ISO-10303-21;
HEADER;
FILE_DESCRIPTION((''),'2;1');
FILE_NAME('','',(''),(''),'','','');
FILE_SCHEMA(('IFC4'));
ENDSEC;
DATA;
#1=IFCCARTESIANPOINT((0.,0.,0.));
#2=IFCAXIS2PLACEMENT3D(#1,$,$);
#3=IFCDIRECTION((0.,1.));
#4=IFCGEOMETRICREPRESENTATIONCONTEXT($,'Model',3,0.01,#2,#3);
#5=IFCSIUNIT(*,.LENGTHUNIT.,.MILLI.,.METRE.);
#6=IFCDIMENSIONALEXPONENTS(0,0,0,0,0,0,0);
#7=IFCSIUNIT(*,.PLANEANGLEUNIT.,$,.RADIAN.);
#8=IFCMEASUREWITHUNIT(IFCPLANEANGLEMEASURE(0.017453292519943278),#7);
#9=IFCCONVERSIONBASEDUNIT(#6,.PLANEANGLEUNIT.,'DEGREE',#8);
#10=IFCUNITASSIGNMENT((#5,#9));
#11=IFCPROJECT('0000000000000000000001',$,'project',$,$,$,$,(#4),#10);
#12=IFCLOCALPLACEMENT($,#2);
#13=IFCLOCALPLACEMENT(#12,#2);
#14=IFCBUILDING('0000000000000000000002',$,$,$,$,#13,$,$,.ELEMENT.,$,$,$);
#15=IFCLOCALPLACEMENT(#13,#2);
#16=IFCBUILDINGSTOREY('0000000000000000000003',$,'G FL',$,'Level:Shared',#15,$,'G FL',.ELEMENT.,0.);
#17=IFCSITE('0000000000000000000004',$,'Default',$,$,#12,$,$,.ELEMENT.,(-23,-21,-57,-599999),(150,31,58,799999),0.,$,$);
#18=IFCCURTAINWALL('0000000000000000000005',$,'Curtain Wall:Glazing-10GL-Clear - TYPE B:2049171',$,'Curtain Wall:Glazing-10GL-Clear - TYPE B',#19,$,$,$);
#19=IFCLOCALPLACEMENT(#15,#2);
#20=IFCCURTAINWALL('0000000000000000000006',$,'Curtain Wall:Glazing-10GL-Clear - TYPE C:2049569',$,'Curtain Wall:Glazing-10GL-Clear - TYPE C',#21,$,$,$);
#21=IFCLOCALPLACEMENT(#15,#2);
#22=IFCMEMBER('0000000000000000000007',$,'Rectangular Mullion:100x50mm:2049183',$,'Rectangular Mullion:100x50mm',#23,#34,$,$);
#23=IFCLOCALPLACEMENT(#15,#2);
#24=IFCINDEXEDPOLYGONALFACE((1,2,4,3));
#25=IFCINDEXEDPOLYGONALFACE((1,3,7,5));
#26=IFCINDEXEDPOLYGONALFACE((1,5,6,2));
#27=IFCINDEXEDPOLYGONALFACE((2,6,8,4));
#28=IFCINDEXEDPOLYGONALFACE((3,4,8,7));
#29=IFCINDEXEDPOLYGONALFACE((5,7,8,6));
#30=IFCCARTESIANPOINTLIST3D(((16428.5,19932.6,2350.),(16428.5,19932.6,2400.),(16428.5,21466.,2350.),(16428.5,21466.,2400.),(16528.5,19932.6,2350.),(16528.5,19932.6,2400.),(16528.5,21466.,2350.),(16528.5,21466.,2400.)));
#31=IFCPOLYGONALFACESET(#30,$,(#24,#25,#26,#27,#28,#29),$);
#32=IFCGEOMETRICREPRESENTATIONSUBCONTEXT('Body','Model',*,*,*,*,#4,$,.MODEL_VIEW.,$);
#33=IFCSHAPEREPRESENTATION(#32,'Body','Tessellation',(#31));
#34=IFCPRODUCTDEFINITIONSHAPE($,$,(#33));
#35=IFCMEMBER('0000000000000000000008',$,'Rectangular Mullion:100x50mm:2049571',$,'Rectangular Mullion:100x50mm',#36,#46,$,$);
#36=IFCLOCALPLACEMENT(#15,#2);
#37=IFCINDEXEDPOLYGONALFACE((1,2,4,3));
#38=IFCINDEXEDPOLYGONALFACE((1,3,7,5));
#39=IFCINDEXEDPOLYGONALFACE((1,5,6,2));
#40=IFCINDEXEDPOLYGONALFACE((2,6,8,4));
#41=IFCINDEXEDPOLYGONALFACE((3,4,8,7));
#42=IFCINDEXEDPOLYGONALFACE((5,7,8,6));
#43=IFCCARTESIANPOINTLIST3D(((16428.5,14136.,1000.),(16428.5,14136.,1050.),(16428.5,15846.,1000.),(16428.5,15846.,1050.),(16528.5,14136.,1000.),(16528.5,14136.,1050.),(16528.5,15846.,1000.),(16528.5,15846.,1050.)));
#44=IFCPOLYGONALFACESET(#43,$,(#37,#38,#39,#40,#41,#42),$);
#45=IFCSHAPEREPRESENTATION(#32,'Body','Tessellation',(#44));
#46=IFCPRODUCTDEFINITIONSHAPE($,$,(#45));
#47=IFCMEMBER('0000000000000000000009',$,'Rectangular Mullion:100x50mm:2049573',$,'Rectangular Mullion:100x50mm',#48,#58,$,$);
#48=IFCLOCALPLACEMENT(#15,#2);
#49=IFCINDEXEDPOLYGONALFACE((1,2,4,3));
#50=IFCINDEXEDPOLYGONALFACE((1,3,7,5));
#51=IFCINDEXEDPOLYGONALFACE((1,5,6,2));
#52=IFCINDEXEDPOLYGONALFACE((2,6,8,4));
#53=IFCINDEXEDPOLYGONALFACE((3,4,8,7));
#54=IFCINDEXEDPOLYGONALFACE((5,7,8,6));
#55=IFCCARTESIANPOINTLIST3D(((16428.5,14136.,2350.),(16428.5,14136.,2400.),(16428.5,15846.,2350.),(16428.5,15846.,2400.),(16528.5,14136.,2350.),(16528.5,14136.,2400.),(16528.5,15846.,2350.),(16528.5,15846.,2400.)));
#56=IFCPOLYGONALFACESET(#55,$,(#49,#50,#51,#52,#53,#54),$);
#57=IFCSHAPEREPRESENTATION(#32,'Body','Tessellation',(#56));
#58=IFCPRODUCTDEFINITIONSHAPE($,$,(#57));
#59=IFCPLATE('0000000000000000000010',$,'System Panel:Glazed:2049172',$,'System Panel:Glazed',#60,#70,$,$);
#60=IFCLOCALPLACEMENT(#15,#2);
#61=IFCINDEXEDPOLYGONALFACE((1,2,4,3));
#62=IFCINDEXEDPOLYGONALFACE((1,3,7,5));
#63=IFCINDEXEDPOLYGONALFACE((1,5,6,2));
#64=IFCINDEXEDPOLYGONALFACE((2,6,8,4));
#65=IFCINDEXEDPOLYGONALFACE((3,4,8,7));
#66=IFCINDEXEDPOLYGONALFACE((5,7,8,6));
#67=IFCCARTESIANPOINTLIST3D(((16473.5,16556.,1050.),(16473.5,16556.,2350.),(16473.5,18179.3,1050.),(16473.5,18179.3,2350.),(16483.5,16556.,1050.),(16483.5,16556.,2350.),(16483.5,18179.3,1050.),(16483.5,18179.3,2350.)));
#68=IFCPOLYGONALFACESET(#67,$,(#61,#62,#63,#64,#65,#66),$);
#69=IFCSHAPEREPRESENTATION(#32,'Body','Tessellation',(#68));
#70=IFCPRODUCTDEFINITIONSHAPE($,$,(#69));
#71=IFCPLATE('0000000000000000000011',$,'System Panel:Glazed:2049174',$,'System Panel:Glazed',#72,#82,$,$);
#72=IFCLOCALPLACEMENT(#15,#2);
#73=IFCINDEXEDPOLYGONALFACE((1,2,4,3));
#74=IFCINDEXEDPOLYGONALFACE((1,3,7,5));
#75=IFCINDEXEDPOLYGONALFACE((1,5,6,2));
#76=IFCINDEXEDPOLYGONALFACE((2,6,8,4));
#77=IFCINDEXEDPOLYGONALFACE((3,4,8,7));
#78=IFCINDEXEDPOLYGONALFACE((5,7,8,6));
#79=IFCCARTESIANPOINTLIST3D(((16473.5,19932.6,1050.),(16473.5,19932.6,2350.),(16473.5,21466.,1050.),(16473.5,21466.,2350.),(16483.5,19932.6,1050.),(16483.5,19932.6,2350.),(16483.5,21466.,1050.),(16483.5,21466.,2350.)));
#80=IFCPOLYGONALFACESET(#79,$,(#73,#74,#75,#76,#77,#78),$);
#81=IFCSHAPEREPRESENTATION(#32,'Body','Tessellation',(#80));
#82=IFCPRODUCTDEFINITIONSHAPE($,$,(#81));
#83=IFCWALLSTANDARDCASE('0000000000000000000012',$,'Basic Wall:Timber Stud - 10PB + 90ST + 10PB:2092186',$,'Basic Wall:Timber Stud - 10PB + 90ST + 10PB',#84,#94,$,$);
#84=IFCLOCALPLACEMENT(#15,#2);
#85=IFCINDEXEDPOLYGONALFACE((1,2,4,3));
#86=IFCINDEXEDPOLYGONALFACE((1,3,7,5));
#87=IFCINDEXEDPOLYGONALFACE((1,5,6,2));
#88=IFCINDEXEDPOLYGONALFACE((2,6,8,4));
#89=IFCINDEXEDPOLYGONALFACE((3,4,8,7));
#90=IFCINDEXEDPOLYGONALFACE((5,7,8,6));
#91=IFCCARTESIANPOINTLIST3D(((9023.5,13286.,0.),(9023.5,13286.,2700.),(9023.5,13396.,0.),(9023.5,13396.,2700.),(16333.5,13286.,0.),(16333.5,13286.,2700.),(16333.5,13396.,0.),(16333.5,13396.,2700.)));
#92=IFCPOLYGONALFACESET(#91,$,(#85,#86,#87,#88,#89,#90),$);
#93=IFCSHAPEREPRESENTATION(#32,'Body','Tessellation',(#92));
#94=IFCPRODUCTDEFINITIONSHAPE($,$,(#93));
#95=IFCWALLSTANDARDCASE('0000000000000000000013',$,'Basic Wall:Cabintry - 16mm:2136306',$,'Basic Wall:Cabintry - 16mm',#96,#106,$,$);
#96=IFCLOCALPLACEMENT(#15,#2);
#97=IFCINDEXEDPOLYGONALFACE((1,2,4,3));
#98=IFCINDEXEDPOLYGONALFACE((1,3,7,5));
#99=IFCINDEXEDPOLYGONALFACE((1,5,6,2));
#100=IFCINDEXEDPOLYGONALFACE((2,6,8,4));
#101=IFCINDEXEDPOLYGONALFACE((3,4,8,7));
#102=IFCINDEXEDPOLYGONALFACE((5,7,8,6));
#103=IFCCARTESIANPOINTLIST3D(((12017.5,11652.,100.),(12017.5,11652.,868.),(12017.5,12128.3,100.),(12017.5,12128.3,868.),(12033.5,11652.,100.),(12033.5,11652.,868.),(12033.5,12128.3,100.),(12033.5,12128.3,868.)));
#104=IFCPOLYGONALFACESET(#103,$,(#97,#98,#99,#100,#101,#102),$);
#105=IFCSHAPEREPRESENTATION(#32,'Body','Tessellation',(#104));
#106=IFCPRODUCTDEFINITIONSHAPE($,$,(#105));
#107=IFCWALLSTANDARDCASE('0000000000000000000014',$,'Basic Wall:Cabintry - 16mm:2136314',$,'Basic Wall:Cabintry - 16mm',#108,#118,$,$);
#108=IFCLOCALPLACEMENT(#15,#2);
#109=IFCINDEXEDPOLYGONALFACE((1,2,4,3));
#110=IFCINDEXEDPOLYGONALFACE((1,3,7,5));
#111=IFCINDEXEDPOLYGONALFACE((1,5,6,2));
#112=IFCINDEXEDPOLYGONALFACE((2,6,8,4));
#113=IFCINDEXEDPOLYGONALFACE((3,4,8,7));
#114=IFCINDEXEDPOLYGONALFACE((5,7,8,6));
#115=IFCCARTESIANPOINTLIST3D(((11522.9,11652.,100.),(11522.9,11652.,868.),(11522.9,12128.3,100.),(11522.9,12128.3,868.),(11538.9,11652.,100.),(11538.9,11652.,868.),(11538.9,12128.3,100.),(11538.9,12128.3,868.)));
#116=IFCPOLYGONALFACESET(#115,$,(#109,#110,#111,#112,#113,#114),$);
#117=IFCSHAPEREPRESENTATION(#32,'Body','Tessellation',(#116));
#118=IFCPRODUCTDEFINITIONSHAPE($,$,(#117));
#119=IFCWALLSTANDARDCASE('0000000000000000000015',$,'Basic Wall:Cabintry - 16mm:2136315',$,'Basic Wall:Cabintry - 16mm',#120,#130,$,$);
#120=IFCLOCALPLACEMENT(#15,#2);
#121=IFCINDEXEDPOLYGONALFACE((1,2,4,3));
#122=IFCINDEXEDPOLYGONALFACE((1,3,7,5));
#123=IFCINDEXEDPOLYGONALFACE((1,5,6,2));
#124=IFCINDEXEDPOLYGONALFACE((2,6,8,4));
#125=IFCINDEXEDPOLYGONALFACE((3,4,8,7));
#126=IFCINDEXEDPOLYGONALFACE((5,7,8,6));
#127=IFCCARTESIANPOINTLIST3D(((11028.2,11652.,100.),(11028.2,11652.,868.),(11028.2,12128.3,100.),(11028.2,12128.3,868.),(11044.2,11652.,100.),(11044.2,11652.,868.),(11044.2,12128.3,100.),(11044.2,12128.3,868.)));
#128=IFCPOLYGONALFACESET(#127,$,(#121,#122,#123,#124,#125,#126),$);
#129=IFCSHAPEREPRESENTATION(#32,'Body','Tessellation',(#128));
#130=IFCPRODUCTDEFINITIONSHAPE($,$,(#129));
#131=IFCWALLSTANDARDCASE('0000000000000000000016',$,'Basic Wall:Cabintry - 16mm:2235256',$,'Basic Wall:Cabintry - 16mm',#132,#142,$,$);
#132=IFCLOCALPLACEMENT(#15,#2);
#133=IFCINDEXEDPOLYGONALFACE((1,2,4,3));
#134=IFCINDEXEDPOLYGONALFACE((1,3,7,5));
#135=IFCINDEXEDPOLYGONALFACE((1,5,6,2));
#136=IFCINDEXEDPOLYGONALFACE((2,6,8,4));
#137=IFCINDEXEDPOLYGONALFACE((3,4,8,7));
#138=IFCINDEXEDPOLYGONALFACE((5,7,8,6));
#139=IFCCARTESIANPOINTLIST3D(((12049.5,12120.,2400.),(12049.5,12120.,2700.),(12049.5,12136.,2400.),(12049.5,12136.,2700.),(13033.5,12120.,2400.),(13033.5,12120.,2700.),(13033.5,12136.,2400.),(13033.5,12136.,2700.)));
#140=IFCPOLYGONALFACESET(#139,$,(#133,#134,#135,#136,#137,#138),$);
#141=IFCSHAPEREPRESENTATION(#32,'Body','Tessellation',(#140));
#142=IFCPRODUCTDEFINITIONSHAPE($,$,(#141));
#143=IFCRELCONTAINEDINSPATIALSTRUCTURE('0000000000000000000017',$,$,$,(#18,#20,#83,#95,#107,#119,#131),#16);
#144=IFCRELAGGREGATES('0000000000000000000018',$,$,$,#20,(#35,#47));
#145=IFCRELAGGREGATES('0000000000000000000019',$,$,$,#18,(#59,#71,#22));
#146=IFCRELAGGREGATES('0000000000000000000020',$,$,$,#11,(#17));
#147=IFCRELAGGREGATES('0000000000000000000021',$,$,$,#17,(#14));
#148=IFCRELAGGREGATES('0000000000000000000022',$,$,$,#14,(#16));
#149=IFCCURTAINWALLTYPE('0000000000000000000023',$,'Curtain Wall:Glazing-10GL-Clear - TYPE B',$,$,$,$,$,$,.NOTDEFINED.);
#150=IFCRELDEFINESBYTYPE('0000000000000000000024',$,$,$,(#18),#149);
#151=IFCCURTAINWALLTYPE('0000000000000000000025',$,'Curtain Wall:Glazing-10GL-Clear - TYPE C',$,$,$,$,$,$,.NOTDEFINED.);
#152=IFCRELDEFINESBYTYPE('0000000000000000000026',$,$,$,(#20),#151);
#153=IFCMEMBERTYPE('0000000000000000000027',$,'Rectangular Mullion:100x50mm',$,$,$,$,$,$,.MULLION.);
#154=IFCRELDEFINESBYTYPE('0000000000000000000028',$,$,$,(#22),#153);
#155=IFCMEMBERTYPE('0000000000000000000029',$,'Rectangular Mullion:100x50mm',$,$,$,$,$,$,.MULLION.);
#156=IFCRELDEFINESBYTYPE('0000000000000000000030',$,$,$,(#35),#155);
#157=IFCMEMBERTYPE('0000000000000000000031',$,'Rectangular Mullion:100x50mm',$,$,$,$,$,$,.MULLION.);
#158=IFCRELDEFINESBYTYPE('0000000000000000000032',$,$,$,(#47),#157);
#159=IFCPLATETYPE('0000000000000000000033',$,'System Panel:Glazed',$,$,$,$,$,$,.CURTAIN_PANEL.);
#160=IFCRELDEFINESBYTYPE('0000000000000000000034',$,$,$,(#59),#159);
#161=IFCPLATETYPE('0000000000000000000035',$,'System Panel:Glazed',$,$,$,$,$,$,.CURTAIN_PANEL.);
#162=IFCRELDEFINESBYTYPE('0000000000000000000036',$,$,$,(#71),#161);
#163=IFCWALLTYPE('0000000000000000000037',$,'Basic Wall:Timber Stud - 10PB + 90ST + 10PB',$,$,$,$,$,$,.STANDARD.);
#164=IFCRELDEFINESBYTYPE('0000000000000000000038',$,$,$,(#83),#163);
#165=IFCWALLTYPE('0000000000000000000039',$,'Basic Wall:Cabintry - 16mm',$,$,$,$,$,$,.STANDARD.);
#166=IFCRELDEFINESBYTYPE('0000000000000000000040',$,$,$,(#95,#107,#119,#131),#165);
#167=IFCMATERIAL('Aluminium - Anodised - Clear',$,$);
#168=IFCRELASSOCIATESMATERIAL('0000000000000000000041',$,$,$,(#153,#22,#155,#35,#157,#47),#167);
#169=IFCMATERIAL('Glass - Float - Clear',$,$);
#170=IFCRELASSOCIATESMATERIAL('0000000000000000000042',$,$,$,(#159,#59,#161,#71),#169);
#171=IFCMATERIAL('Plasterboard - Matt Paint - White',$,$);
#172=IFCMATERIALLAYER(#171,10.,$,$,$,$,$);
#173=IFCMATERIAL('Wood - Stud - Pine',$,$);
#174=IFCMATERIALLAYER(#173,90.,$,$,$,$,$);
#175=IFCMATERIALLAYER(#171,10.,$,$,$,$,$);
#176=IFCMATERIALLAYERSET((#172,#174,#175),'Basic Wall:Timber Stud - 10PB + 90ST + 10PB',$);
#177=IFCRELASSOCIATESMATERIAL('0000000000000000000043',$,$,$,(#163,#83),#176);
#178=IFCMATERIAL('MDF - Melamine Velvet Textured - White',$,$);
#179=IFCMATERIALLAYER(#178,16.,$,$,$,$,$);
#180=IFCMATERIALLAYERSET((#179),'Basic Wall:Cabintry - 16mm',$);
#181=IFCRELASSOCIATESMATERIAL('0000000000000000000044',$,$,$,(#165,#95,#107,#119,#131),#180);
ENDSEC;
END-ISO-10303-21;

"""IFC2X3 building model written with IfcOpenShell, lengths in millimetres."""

from ifc_helpers import new_model, entity, si_unit, converted_unit, direction, frame, frame_2d, origin, origin_2d_with_axis, place, context, subcontext, project, spatial, rectangle, extrude, source, transform, mapped, material, layer, layer_set, layer_usage, type_object, type_shapes, element, aggregate, save


model = new_model("IFC2X3")

# Units and contexts
model_context = context("Model", 3, precision=0.01, world=origin(), true_north=direction((0.0, 1.0)))
body_context = subcontext(model_context, "Body", "Model", "MODEL_VIEW")
ifc_project = project(units=[si_unit("LENGTHUNIT", "METRE", prefix="MILLI"), converted_unit("PLANEANGLEUNIT", "DEGREE", entity("IfcPlaneAngleMeasure", 0.017453292519943278), si_unit("PLANEANGLEUNIT", "RADIAN"), dimensions=[0, 0, 0, 0, 0, 0, 0])], contexts=[model_context])

# Site, building, storey
site_placement = place(None, origin())
site = spatial("IfcSite", under=ifc_project, at=site_placement, Name="Default", CompositionType="ELEMENT", RefLatitude=(-23, -21, -57, -599999), RefLongitude=(150, 31, 58, 799999), RefElevation=0.0)
building_placement = place(site_placement, origin())
building = spatial("IfcBuilding", under=site, at=building_placement, CompositionType="ELEMENT")
storey_placement = place(building_placement, origin())
storey = spatial("IfcBuildingStorey", under=building, at=storey_placement, Name="G FL", ObjectType="Level:Shared", LongName="G FL", CompositionType="ELEMENT", Elevation=0.0)

# Curtain walls
curtain_wall_type_1 = type_object("IfcCurtainWallType", Name="Curtain Wall:Glazing-10GL-Clear - TYPE B", PredefinedType="NOTDEFINED")
curtain_wall_1_placement = place(storey_placement, origin())
curtain_wall_1 = element("IfcCurtainWall", 1, at=curtain_wall_1_placement, inside=storey, type_object=curtain_wall_type_1, Name="Curtain Wall:Glazing-10GL-Clear - TYPE B:2049171", ObjectType="Curtain Wall:Glazing-10GL-Clear - TYPE B")
ifc_material_1 = material(Name="Aluminium - Anodised - Clear")
curtain_wall_type_2 = type_object("IfcCurtainWallType", Name="Curtain Wall:Glazing-10GL-Clear - TYPE C", PredefinedType="NOTDEFINED")
curtain_wall_2_placement = place(storey_placement, origin())
curtain_wall_2 = element("IfcCurtainWall", 2, at=curtain_wall_2_placement, inside=storey, type_object=curtain_wall_type_2, Name="Curtain Wall:Glazing-10GL-Clear - TYPE C:2049569", ObjectType="Curtain Wall:Glazing-10GL-Clear - TYPE C")

# Members
member_type_1 = type_object("IfcMemberType", Name="Rectangular Mullion:100x50mm", PredefinedType="MULLION", material=ifc_material_1)
shared_shape_1 = source(origin(), body_context, "Body", "SweptSolid", [
    extrude(rectangle(XDim=50.0, YDim=100.0, at=frame_2d((0.0, 0.0), x_axis=(1.0, 0.0))), frame((-25.0, 0.0, -1533.3), z_axis=(0.0, 0.0, 1.0), x_axis=(-1.0, 0.0, 0.0)), (0.0, 0.0, 1.0), 1533.3),
])
type_shapes(member_type_1, [shared_shape_1])
member_1_placement = place(curtain_wall_1_placement, frame((16478.5, 21466.0, 2400.0), z_axis=(0.0, 1.0, 0.0), x_axis=(0.0, 0.0, 1.0)))
member_1 = element("IfcMember", 3, at=member_1_placement, type_object=member_type_1, material=ifc_material_1, Name="Rectangular Mullion:100x50mm:2049183", ObjectType="Rectangular Mullion:100x50mm", context=body_context, shape_type="MappedRepresentation", body=[
    mapped(shared_shape_1, transform((0.0, 0.0, 0.0), scale=1.0)),
])
member_type_2 = type_object("IfcMemberType", Name="Rectangular Mullion:100x50mm", PredefinedType="MULLION", material=ifc_material_1)
shared_shape_2 = source(origin(), body_context, "Body", "SweptSolid", [
    extrude(rectangle(XDim=50.0, YDim=100.0, at=frame_2d((0.0, 0.0), x_axis=(1.0, 0.0))), frame((-25.0, 0.0, -1710.0), z_axis=(0.0, 0.0, 1.0), x_axis=(-1.0, 0.0, 0.0)), (0.0, 0.0, 1.0), 1710.0),
])
type_shapes(member_type_2, [shared_shape_2])
member_2_placement = place(curtain_wall_2_placement, frame((16478.5, 15846.0, 1000.0), z_axis=(0.0, 1.0, 0.0), x_axis=(0.0, 0.0, -1.0)))
member_2 = element("IfcMember", 4, at=member_2_placement, type_object=member_type_2, material=ifc_material_1, Name="Rectangular Mullion:100x50mm:2049571", ObjectType="Rectangular Mullion:100x50mm", context=body_context, shape_type="MappedRepresentation", body=[
    mapped(shared_shape_2, transform((0.0, 0.0, 0.0), scale=1.0)),
])
member_type_3 = type_object("IfcMemberType", Name="Rectangular Mullion:100x50mm", PredefinedType="MULLION", material=ifc_material_1)
shared_shape_3 = source(origin(), body_context, "Body", "SweptSolid", [
    extrude(rectangle(XDim=50.0, YDim=100.0, at=frame_2d((0.0, 0.0), x_axis=(1.0, 0.0))), frame((-25.0, 0.0, -1710.0), z_axis=(0.0, 0.0, 1.0), x_axis=(-1.0, 0.0, 0.0)), (0.0, 0.0, 1.0), 1710.0),
])
type_shapes(member_type_3, [shared_shape_3])
member_3_placement = place(curtain_wall_2_placement, frame((16478.5, 14136.0, 2400.0), z_axis=(0.0, -1.0, 0.0), x_axis=(0.0, 0.0, 1.0)))
member_3 = element("IfcMember", 5, at=member_3_placement, type_object=member_type_3, material=ifc_material_1, Name="Rectangular Mullion:100x50mm:2049573", ObjectType="Rectangular Mullion:100x50mm", context=body_context, shape_type="MappedRepresentation", body=[
    mapped(shared_shape_3, transform((0.0, 0.0, 0.0), scale=1.0)),
])
aggregate(curtain_wall_2, [member_2, member_3])

# Plates
ifc_material_2 = material(Name="Glass - Float - Clear")
plate_type_1 = type_object("IfcPlateType", Name="System Panel:Glazed", PredefinedType="CURTAIN_PANEL", material=ifc_material_2)
shared_shape_4 = source(origin(), body_context, "Body", "SweptSolid", [
    extrude(rectangle(XDim=10.0, YDim=1623.3, at=origin_2d_with_axis()), frame((0.0, 0.0, 0.0), z_axis=(0.0, 0.0, 1.0), x_axis=(0.0, 1.0, 0.0)), (0.0, 0.0, 1.0), 1300.0),
])
type_shapes(plate_type_1, [shared_shape_4])
plate_1_placement = place(curtain_wall_1_placement, frame((16478.5, 17367.6, 1050.0), z_axis=(0.0, 0.0, 1.0), x_axis=(0.0, 1.0, 0.0)))
plate_1 = element("IfcPlate", 6, at=plate_1_placement, type_object=plate_type_1, material=ifc_material_2, Name="System Panel:Glazed:2049172", ObjectType="System Panel:Glazed", context=body_context, shape_type="MappedRepresentation", body=[
    mapped(shared_shape_4, transform((0.0, 0.0, 0.0), scale=1.0)),
])
plate_type_2 = type_object("IfcPlateType", Name="System Panel:Glazed", PredefinedType="CURTAIN_PANEL", material=ifc_material_2)
shared_shape_5 = source(origin(), body_context, "Body", "SweptSolid", [
    extrude(rectangle(XDim=10.0, YDim=1533.3, at=origin_2d_with_axis()), frame((0.0, 0.0, 0.0), z_axis=(0.0, 0.0, 1.0), x_axis=(0.0, 1.0, 0.0)), (0.0, 0.0, 1.0), 1300.0),
])
type_shapes(plate_type_2, [shared_shape_5])
plate_2_placement = place(curtain_wall_1_placement, frame((16478.5, 20699.3, 1050.0), z_axis=(0.0, 0.0, 1.0), x_axis=(0.0, 1.0, 0.0)))
plate_2 = element("IfcPlate", 7, at=plate_2_placement, type_object=plate_type_2, material=ifc_material_2, Name="System Panel:Glazed:2049174", ObjectType="System Panel:Glazed", context=body_context, shape_type="MappedRepresentation", body=[
    mapped(shared_shape_5, transform((0.0, 0.0, 0.0), scale=1.0)),
])
aggregate(curtain_wall_1, [plate_1, plate_2, member_1])

# Walls
ifc_material_3 = material(Name="Plasterboard - Matt Paint - White")
ifc_layer_1 = layer(ifc_material_3, 10.0)
ifc_material_4 = material(Name="Wood - Stud - Pine")
ifc_layer_2 = layer(ifc_material_4, 90.0)
ifc_layer_3 = layer(ifc_material_3, 10.0)
ifc_layer_set_1 = layer_set([ifc_layer_1, ifc_layer_2, ifc_layer_3], Name="Basic Wall:Timber Stud - 10PB + 90ST + 10PB")
ifc_layer_usage_1 = layer_usage(ifc_layer_set_1, "AXIS2", "NEGATIVE", 55.0)
wall_type_1 = type_object("IfcWallType", Name="Basic Wall:Timber Stud - 10PB + 90ST + 10PB", PredefinedType="STANDARD", material=ifc_layer_set_1)
wall_1_placement = place(storey_placement, frame((16333.5, 13341.0, 0.0), z_axis=(0.0, 0.0, 1.0), x_axis=(-1.0, 0.0, 0.0)))
element("IfcWallStandardCase", 8, at=wall_1_placement, inside=storey, type_object=wall_type_1, material=ifc_layer_usage_1, Name="Basic Wall:Timber Stud - 10PB + 90ST + 10PB:2092186", ObjectType="Basic Wall:Timber Stud - 10PB + 90ST + 10PB", context=body_context, shape_type="SweptSolid", body=[
    extrude(rectangle(XDim=7310.0, YDim=110.0, at=frame_2d((3655.0, 0.0), x_axis=(-1.0, 0.0))), origin(), (0.0, 0.0, 1.0), 2700.0),
])
ifc_material_5 = material(Name="MDF - Melamine Velvet Textured - White")
ifc_layer_4 = layer(ifc_material_5, 16.0)
ifc_layer_set_2 = layer_set([ifc_layer_4], Name="Basic Wall:Cabintry - 16mm")
ifc_layer_usage_2 = layer_usage(ifc_layer_set_2, "AXIS2", "POSITIVE", -8.0)
wall_type_2 = type_object("IfcWallType", Name="Basic Wall:Cabintry - 16mm", PredefinedType="STANDARD", material=ifc_layer_set_2)
wall_2_placement = place(storey_placement, frame((12025.5, 12128.3, 100.0), z_axis=(0.0, 0.0, 1.0), x_axis=(0.0, -1.0, 0.0)))
element("IfcWallStandardCase", 9, at=wall_2_placement, inside=storey, type_object=wall_type_2, material=ifc_layer_usage_2, Name="Basic Wall:Cabintry - 16mm:2136306", ObjectType="Basic Wall:Cabintry - 16mm", context=body_context, shape_type="SweptSolid", body=[
    extrude(rectangle(XDim=476.4, YDim=16.0, at=frame_2d((238.2, 0.0), x_axis=(-1.0, 0.0))), origin(), (0.0, 0.0, 1.0), 768.0),
])
ifc_layer_usage_3 = layer_usage(ifc_layer_set_2, "AXIS2", "POSITIVE", -8.0)
wall_3_placement = place(storey_placement, frame((11530.9, 12128.3, 100.0), z_axis=(0.0, 0.0, 1.0), x_axis=(0.0, -1.0, 0.0)))
element("IfcWallStandardCase", 10, at=wall_3_placement, inside=storey, type_object=wall_type_2, material=ifc_layer_usage_3, Name="Basic Wall:Cabintry - 16mm:2136314", ObjectType="Basic Wall:Cabintry - 16mm", context=body_context, shape_type="SweptSolid", body=[
    extrude(rectangle(XDim=476.4, YDim=16.0, at=frame_2d((238.2, 0.0), x_axis=(-1.0, 0.0))), origin(), (0.0, 0.0, 1.0), 768.0),
])
ifc_layer_usage_4 = layer_usage(ifc_layer_set_2, "AXIS2", "POSITIVE", -8.0)
wall_4_placement = place(storey_placement, frame((11036.2, 12128.3, 100.0), z_axis=(0.0, 0.0, 1.0), x_axis=(0.0, -1.0, 0.0)))
element("IfcWallStandardCase", 11, at=wall_4_placement, inside=storey, type_object=wall_type_2, material=ifc_layer_usage_4, Name="Basic Wall:Cabintry - 16mm:2136315", ObjectType="Basic Wall:Cabintry - 16mm", context=body_context, shape_type="SweptSolid", body=[
    extrude(rectangle(XDim=476.4, YDim=16.0, at=frame_2d((238.2, 0.0), x_axis=(-1.0, 0.0))), origin(), (0.0, 0.0, 1.0), 768.0),
])
ifc_layer_usage_5 = layer_usage(ifc_layer_set_2, "AXIS2", "NEGATIVE", 8.0)
wall_5_placement = place(storey_placement, frame((12049.5, 12128.0, 2400.0)))
element("IfcWallStandardCase", 12, at=wall_5_placement, inside=storey, type_object=wall_type_2, material=ifc_layer_usage_5, Name="Basic Wall:Cabintry - 16mm:2235256", ObjectType="Basic Wall:Cabintry - 16mm", context=body_context, shape_type="SweptSolid", body=[
    extrude(rectangle(XDim=984.0, YDim=16.0, at=frame_2d((492.0, 0.0), x_axis=(-1.0, 0.0))), origin(), (0.0, 0.0, 1.0), 300.0),
])

save(model, "model.ifc")
